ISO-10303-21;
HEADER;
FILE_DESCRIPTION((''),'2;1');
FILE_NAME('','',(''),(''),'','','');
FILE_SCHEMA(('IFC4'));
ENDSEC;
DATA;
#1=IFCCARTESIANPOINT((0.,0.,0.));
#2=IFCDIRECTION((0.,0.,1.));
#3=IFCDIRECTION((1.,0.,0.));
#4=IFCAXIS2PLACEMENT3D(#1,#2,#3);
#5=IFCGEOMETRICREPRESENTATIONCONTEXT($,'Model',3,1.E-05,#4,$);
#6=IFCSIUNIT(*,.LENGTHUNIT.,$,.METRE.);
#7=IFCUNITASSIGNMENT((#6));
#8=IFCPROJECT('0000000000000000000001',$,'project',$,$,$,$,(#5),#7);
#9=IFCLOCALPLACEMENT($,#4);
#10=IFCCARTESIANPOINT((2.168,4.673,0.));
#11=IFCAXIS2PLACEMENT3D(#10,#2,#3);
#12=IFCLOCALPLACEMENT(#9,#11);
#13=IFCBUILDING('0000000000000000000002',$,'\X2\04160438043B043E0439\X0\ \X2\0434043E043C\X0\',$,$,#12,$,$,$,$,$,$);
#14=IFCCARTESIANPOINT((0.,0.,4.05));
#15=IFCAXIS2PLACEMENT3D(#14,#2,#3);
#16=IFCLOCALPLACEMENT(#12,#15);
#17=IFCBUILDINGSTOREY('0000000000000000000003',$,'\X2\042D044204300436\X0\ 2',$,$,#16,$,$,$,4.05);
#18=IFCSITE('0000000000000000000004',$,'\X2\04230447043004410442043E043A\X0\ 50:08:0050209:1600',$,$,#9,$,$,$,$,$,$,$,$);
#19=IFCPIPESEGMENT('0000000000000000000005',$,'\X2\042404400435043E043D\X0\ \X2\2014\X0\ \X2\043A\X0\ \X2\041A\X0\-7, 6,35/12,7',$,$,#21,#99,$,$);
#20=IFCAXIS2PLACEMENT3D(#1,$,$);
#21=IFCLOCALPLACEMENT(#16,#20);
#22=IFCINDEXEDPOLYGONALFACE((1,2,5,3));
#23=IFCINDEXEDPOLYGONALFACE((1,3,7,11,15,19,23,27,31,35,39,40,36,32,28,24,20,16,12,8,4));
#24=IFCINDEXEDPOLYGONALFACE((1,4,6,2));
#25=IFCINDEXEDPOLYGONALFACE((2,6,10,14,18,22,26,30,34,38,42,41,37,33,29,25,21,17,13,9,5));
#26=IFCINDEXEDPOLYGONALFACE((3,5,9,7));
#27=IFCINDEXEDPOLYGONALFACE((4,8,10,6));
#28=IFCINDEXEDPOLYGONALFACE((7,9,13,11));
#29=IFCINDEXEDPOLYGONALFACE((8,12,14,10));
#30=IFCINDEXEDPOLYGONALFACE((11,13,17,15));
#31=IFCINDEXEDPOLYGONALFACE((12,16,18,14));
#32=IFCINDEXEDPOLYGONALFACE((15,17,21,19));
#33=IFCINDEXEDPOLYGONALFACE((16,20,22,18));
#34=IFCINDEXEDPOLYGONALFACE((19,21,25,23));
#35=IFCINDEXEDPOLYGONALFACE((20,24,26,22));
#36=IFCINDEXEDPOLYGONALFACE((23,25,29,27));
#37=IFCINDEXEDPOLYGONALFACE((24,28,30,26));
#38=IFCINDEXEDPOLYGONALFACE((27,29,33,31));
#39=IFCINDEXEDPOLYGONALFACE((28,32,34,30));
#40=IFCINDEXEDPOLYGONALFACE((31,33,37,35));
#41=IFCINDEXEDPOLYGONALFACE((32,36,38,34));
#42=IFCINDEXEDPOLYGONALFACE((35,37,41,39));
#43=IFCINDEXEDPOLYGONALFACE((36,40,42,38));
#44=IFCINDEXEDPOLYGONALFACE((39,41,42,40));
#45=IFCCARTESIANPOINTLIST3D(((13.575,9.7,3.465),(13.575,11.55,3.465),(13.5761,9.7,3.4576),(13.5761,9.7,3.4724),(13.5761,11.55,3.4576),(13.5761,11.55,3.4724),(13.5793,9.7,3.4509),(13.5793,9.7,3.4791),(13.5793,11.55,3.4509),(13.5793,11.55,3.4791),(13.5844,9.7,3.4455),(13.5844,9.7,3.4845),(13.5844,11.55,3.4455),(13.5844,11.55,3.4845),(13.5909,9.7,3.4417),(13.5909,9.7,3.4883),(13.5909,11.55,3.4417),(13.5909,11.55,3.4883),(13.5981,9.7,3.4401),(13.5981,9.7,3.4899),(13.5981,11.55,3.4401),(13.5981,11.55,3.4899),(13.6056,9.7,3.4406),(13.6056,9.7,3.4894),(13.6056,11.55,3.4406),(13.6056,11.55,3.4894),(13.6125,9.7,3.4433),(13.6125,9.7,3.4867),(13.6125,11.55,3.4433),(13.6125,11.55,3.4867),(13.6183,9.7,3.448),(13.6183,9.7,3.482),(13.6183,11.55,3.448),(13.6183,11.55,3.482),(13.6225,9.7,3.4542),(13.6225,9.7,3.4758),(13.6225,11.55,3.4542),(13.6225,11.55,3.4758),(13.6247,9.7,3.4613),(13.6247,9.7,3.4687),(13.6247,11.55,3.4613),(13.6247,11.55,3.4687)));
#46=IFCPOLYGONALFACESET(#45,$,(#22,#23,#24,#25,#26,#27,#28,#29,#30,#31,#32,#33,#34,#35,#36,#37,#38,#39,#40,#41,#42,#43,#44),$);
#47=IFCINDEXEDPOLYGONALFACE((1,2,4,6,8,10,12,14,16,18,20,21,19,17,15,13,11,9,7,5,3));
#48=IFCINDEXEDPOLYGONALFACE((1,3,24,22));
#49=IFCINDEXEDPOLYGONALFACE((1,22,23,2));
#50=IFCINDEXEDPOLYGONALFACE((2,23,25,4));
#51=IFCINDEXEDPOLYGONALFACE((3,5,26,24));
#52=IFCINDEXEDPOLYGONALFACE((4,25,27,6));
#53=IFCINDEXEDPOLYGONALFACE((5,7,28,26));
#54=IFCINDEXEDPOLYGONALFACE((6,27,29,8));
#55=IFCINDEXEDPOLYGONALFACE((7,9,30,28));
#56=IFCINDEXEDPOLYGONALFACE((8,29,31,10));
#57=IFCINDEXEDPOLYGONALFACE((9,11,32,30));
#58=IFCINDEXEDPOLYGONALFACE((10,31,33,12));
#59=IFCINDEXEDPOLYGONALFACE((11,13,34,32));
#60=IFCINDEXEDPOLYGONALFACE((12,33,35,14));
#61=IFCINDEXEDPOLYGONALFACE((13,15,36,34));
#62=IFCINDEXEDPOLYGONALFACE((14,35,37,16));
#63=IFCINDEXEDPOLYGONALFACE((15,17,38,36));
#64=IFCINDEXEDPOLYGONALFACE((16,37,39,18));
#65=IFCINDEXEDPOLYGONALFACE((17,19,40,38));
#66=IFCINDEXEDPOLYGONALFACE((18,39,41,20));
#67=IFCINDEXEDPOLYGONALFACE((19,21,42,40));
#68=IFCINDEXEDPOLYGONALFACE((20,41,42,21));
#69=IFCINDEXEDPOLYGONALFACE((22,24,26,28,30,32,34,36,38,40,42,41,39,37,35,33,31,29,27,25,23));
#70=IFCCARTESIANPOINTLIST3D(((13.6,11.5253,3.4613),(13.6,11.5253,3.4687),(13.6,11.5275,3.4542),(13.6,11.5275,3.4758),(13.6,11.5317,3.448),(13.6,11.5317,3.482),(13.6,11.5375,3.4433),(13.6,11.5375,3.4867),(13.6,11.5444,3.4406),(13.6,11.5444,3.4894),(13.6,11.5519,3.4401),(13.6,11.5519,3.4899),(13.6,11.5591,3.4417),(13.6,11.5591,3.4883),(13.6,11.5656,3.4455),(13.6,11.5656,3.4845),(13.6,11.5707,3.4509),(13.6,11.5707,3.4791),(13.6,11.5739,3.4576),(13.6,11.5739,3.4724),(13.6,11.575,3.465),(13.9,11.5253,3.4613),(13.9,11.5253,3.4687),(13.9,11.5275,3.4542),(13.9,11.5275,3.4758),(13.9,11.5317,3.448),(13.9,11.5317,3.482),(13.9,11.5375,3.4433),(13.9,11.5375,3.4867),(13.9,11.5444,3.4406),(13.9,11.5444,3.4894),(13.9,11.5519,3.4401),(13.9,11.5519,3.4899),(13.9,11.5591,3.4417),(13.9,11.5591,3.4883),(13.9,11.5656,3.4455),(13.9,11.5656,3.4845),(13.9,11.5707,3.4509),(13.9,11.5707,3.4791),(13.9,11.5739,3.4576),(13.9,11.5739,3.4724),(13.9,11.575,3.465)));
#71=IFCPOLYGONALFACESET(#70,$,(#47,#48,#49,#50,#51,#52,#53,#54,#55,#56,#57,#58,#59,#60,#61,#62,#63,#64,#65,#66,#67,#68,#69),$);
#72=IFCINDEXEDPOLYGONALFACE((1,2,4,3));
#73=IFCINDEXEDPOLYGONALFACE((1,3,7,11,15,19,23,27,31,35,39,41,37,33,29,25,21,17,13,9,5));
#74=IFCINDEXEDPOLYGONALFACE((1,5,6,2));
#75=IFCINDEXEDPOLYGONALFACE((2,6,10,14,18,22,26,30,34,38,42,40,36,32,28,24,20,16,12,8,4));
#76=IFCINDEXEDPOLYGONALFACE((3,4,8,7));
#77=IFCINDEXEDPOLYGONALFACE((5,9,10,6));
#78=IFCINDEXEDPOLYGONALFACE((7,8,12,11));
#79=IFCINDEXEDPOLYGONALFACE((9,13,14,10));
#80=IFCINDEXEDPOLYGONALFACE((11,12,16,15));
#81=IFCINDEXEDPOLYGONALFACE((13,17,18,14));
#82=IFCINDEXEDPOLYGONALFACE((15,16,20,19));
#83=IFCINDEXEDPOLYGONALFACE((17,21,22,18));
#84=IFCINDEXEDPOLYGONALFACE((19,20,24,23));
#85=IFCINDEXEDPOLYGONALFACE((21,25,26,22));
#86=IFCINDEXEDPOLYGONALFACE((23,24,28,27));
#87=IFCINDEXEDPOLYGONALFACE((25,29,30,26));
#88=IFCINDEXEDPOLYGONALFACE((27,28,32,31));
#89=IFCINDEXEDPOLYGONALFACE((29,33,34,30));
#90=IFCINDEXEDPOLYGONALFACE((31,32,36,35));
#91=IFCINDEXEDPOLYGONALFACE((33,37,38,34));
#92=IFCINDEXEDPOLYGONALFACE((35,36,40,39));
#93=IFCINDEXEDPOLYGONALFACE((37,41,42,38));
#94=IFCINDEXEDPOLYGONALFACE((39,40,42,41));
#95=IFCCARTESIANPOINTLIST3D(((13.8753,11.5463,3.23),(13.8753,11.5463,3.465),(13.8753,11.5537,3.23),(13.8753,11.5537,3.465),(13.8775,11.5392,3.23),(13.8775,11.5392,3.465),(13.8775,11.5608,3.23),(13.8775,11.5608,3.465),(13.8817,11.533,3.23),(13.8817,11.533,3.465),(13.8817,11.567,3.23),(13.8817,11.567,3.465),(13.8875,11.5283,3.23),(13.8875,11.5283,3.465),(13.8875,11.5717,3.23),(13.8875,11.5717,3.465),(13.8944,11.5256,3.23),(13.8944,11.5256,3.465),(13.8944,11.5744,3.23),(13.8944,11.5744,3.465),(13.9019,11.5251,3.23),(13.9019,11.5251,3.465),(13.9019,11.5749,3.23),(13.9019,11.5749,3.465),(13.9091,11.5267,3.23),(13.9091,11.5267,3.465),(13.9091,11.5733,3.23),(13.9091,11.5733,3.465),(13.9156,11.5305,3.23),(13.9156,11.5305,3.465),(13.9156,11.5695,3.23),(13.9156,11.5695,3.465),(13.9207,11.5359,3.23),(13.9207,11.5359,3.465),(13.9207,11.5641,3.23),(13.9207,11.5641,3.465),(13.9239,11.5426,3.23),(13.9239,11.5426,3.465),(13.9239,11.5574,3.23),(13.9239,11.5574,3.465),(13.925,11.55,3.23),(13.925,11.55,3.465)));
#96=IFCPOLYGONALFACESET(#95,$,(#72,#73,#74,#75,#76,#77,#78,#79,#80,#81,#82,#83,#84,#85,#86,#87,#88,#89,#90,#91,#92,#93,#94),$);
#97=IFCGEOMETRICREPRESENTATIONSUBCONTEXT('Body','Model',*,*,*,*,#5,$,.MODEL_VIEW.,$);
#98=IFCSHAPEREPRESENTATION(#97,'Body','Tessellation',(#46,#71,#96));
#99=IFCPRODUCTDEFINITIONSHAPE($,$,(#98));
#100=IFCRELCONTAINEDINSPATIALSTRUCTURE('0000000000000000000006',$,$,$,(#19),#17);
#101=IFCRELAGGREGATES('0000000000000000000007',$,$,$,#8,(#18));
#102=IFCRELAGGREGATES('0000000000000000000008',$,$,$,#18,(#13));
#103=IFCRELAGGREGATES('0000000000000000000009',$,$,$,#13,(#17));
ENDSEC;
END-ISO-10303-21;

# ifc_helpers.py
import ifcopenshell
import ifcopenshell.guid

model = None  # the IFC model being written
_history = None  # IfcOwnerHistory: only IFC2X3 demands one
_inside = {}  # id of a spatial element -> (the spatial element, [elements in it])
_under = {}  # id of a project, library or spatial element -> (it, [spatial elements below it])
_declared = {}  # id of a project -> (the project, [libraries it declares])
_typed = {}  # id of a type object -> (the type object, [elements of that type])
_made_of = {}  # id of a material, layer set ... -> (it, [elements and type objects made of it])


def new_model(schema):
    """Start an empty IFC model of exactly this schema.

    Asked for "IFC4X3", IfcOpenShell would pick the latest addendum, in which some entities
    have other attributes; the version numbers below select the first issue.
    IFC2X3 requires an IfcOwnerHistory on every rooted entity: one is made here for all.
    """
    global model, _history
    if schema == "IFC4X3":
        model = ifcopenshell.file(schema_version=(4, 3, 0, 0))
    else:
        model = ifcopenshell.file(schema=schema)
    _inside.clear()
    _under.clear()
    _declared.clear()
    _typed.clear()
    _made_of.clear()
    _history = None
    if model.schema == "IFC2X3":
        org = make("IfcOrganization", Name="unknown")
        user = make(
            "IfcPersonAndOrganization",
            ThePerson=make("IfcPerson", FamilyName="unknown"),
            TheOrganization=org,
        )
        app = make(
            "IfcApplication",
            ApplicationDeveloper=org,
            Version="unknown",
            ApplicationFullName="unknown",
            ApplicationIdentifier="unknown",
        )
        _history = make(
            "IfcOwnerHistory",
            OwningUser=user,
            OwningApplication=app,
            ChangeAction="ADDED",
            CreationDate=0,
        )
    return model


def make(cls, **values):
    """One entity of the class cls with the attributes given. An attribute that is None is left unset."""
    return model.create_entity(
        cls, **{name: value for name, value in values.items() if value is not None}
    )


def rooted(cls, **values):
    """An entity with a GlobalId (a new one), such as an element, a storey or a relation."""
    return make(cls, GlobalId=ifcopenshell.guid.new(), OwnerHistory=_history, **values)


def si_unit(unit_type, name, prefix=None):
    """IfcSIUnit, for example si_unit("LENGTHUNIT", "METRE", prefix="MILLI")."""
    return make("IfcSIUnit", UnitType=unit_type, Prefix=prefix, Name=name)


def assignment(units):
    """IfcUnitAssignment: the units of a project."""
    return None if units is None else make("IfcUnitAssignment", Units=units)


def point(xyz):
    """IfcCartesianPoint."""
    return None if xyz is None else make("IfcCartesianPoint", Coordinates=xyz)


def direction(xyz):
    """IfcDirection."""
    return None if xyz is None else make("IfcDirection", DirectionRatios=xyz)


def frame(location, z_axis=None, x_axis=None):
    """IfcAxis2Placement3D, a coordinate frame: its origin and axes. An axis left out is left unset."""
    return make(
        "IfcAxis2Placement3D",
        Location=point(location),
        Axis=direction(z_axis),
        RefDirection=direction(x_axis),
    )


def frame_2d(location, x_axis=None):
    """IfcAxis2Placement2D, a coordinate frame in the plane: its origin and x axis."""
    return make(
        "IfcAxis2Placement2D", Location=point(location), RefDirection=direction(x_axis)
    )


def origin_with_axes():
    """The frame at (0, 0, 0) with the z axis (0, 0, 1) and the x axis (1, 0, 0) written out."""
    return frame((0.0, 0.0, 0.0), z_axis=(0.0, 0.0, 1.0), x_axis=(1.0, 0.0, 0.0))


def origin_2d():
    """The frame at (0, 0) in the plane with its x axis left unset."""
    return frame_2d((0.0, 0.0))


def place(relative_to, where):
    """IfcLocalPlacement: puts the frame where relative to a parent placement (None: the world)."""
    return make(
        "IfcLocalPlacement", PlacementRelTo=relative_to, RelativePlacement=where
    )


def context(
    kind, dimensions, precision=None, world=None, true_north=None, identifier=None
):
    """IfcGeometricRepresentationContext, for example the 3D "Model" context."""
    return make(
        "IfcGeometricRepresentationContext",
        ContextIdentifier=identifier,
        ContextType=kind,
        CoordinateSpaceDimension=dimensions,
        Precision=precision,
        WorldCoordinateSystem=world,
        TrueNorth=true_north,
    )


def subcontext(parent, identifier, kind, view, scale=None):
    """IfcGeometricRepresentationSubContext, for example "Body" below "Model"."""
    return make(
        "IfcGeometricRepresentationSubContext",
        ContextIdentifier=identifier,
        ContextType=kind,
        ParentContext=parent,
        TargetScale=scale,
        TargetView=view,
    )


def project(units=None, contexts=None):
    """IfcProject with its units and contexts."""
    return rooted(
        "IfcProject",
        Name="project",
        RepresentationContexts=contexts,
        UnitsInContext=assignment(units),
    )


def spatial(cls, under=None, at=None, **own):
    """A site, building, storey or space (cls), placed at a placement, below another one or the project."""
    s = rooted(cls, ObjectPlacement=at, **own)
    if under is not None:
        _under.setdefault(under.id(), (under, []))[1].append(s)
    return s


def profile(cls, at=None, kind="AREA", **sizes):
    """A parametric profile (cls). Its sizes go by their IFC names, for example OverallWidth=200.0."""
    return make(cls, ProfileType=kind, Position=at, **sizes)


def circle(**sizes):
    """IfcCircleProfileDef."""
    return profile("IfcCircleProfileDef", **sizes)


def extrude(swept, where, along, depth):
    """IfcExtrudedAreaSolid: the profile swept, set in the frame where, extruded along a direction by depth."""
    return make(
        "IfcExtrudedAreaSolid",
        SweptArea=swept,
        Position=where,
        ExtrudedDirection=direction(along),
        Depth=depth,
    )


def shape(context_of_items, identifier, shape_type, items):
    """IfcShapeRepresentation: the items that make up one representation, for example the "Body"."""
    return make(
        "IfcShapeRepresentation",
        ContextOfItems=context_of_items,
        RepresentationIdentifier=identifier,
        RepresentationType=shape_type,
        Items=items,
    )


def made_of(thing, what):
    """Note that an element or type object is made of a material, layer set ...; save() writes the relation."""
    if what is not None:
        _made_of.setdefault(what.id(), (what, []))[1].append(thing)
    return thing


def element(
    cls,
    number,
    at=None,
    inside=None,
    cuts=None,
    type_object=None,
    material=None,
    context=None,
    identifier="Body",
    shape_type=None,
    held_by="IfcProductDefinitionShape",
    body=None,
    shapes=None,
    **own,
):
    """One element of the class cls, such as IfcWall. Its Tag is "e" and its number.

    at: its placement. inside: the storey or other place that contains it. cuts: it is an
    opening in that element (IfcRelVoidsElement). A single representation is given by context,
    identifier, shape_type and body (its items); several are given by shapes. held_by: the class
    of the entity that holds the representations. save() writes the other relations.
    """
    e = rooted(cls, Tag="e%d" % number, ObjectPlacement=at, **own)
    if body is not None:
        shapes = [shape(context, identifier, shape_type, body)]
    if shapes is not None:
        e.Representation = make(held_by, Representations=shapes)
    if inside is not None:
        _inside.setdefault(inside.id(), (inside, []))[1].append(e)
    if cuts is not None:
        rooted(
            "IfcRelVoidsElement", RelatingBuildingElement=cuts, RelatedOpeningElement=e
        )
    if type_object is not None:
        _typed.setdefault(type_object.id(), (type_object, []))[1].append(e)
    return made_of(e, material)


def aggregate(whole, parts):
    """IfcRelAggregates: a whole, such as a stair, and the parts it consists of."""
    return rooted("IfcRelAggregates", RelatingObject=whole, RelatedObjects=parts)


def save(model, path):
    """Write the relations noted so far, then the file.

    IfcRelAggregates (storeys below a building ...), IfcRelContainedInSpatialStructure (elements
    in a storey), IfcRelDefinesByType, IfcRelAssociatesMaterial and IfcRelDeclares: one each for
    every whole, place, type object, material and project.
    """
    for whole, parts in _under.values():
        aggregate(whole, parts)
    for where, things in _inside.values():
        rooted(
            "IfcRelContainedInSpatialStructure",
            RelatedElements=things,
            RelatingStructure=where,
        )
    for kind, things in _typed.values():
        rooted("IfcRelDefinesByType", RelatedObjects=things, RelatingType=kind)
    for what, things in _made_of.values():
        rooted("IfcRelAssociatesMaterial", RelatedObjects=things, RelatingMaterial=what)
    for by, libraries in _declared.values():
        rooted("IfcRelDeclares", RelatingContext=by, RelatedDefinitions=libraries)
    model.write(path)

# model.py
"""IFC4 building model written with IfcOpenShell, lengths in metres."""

from ifc_helpers import new_model, si_unit, frame, origin_with_axes, origin_2d, place, context, subcontext, project, spatial, circle, extrude, element, save


model = new_model("IFC4")

# Units and contexts
model_context = context("Model", 3, precision=1e-05, world=origin_with_axes())
body_context = subcontext(model_context, "Body", "Model", "MODEL_VIEW")
ifc_project = project(units=[si_unit("LENGTHUNIT", "METRE")], contexts=[model_context])

# Site, building, storey
site_placement = place(None, origin_with_axes())
site = spatial("IfcSite", under=ifc_project, at=site_placement, Name="Участок 50:08:0050209:1600")
building_placement = place(site_placement, frame((2.168, 4.673, 0.0), z_axis=(0.0, 0.0, 1.0), x_axis=(1.0, 0.0, 0.0)))
building = spatial("IfcBuilding", under=site, at=building_placement, Name="Жилой дом")
storey_placement = place(building_placement, frame((0.0, 0.0, 4.05), z_axis=(0.0, 0.0, 1.0), x_axis=(1.0, 0.0, 0.0)))
storey = spatial("IfcBuildingStorey", under=building, at=storey_placement, Name="Этаж 2", Elevation=4.05)

# Pipe segment
pipe_segment_1_placement = place(storey_placement, frame((0.0, 0.0, -4.05), z_axis=(0.0, 0.0, 1.0), x_axis=(1.0, 0.0, 0.0)))
element("IfcPipeSegment", 1, at=pipe_segment_1_placement, inside=storey, Name="Фреон — к К-7, 6,35/12,7", context=body_context, shape_type="SweptSolid", body=[
    extrude(circle(Radius=0.025, at=origin_2d()), frame((13.6, 9.7, 7.515), z_axis=(0.0, 1.0, 0.0), x_axis=(-1.0, 0.0, 0.0)), (0.0, 0.0, 1.0), 1.85),
    extrude(circle(Radius=0.025, at=origin_2d()), frame((13.6, 11.55, 7.515), z_axis=(1.0, 0.0, 0.0), x_axis=(0.0, 1.0, 0.0)), (0.0, 0.0, 1.0), 0.3),
    extrude(circle(Radius=0.025, at=origin_2d()), frame((13.9, 11.55, 7.515), z_axis=(0.0, 0.0, -1.0), x_axis=(1.0, 0.0, 0.0)), (0.0, 0.0, 1.0), 0.235),
])

save(model, "model.ifc")
